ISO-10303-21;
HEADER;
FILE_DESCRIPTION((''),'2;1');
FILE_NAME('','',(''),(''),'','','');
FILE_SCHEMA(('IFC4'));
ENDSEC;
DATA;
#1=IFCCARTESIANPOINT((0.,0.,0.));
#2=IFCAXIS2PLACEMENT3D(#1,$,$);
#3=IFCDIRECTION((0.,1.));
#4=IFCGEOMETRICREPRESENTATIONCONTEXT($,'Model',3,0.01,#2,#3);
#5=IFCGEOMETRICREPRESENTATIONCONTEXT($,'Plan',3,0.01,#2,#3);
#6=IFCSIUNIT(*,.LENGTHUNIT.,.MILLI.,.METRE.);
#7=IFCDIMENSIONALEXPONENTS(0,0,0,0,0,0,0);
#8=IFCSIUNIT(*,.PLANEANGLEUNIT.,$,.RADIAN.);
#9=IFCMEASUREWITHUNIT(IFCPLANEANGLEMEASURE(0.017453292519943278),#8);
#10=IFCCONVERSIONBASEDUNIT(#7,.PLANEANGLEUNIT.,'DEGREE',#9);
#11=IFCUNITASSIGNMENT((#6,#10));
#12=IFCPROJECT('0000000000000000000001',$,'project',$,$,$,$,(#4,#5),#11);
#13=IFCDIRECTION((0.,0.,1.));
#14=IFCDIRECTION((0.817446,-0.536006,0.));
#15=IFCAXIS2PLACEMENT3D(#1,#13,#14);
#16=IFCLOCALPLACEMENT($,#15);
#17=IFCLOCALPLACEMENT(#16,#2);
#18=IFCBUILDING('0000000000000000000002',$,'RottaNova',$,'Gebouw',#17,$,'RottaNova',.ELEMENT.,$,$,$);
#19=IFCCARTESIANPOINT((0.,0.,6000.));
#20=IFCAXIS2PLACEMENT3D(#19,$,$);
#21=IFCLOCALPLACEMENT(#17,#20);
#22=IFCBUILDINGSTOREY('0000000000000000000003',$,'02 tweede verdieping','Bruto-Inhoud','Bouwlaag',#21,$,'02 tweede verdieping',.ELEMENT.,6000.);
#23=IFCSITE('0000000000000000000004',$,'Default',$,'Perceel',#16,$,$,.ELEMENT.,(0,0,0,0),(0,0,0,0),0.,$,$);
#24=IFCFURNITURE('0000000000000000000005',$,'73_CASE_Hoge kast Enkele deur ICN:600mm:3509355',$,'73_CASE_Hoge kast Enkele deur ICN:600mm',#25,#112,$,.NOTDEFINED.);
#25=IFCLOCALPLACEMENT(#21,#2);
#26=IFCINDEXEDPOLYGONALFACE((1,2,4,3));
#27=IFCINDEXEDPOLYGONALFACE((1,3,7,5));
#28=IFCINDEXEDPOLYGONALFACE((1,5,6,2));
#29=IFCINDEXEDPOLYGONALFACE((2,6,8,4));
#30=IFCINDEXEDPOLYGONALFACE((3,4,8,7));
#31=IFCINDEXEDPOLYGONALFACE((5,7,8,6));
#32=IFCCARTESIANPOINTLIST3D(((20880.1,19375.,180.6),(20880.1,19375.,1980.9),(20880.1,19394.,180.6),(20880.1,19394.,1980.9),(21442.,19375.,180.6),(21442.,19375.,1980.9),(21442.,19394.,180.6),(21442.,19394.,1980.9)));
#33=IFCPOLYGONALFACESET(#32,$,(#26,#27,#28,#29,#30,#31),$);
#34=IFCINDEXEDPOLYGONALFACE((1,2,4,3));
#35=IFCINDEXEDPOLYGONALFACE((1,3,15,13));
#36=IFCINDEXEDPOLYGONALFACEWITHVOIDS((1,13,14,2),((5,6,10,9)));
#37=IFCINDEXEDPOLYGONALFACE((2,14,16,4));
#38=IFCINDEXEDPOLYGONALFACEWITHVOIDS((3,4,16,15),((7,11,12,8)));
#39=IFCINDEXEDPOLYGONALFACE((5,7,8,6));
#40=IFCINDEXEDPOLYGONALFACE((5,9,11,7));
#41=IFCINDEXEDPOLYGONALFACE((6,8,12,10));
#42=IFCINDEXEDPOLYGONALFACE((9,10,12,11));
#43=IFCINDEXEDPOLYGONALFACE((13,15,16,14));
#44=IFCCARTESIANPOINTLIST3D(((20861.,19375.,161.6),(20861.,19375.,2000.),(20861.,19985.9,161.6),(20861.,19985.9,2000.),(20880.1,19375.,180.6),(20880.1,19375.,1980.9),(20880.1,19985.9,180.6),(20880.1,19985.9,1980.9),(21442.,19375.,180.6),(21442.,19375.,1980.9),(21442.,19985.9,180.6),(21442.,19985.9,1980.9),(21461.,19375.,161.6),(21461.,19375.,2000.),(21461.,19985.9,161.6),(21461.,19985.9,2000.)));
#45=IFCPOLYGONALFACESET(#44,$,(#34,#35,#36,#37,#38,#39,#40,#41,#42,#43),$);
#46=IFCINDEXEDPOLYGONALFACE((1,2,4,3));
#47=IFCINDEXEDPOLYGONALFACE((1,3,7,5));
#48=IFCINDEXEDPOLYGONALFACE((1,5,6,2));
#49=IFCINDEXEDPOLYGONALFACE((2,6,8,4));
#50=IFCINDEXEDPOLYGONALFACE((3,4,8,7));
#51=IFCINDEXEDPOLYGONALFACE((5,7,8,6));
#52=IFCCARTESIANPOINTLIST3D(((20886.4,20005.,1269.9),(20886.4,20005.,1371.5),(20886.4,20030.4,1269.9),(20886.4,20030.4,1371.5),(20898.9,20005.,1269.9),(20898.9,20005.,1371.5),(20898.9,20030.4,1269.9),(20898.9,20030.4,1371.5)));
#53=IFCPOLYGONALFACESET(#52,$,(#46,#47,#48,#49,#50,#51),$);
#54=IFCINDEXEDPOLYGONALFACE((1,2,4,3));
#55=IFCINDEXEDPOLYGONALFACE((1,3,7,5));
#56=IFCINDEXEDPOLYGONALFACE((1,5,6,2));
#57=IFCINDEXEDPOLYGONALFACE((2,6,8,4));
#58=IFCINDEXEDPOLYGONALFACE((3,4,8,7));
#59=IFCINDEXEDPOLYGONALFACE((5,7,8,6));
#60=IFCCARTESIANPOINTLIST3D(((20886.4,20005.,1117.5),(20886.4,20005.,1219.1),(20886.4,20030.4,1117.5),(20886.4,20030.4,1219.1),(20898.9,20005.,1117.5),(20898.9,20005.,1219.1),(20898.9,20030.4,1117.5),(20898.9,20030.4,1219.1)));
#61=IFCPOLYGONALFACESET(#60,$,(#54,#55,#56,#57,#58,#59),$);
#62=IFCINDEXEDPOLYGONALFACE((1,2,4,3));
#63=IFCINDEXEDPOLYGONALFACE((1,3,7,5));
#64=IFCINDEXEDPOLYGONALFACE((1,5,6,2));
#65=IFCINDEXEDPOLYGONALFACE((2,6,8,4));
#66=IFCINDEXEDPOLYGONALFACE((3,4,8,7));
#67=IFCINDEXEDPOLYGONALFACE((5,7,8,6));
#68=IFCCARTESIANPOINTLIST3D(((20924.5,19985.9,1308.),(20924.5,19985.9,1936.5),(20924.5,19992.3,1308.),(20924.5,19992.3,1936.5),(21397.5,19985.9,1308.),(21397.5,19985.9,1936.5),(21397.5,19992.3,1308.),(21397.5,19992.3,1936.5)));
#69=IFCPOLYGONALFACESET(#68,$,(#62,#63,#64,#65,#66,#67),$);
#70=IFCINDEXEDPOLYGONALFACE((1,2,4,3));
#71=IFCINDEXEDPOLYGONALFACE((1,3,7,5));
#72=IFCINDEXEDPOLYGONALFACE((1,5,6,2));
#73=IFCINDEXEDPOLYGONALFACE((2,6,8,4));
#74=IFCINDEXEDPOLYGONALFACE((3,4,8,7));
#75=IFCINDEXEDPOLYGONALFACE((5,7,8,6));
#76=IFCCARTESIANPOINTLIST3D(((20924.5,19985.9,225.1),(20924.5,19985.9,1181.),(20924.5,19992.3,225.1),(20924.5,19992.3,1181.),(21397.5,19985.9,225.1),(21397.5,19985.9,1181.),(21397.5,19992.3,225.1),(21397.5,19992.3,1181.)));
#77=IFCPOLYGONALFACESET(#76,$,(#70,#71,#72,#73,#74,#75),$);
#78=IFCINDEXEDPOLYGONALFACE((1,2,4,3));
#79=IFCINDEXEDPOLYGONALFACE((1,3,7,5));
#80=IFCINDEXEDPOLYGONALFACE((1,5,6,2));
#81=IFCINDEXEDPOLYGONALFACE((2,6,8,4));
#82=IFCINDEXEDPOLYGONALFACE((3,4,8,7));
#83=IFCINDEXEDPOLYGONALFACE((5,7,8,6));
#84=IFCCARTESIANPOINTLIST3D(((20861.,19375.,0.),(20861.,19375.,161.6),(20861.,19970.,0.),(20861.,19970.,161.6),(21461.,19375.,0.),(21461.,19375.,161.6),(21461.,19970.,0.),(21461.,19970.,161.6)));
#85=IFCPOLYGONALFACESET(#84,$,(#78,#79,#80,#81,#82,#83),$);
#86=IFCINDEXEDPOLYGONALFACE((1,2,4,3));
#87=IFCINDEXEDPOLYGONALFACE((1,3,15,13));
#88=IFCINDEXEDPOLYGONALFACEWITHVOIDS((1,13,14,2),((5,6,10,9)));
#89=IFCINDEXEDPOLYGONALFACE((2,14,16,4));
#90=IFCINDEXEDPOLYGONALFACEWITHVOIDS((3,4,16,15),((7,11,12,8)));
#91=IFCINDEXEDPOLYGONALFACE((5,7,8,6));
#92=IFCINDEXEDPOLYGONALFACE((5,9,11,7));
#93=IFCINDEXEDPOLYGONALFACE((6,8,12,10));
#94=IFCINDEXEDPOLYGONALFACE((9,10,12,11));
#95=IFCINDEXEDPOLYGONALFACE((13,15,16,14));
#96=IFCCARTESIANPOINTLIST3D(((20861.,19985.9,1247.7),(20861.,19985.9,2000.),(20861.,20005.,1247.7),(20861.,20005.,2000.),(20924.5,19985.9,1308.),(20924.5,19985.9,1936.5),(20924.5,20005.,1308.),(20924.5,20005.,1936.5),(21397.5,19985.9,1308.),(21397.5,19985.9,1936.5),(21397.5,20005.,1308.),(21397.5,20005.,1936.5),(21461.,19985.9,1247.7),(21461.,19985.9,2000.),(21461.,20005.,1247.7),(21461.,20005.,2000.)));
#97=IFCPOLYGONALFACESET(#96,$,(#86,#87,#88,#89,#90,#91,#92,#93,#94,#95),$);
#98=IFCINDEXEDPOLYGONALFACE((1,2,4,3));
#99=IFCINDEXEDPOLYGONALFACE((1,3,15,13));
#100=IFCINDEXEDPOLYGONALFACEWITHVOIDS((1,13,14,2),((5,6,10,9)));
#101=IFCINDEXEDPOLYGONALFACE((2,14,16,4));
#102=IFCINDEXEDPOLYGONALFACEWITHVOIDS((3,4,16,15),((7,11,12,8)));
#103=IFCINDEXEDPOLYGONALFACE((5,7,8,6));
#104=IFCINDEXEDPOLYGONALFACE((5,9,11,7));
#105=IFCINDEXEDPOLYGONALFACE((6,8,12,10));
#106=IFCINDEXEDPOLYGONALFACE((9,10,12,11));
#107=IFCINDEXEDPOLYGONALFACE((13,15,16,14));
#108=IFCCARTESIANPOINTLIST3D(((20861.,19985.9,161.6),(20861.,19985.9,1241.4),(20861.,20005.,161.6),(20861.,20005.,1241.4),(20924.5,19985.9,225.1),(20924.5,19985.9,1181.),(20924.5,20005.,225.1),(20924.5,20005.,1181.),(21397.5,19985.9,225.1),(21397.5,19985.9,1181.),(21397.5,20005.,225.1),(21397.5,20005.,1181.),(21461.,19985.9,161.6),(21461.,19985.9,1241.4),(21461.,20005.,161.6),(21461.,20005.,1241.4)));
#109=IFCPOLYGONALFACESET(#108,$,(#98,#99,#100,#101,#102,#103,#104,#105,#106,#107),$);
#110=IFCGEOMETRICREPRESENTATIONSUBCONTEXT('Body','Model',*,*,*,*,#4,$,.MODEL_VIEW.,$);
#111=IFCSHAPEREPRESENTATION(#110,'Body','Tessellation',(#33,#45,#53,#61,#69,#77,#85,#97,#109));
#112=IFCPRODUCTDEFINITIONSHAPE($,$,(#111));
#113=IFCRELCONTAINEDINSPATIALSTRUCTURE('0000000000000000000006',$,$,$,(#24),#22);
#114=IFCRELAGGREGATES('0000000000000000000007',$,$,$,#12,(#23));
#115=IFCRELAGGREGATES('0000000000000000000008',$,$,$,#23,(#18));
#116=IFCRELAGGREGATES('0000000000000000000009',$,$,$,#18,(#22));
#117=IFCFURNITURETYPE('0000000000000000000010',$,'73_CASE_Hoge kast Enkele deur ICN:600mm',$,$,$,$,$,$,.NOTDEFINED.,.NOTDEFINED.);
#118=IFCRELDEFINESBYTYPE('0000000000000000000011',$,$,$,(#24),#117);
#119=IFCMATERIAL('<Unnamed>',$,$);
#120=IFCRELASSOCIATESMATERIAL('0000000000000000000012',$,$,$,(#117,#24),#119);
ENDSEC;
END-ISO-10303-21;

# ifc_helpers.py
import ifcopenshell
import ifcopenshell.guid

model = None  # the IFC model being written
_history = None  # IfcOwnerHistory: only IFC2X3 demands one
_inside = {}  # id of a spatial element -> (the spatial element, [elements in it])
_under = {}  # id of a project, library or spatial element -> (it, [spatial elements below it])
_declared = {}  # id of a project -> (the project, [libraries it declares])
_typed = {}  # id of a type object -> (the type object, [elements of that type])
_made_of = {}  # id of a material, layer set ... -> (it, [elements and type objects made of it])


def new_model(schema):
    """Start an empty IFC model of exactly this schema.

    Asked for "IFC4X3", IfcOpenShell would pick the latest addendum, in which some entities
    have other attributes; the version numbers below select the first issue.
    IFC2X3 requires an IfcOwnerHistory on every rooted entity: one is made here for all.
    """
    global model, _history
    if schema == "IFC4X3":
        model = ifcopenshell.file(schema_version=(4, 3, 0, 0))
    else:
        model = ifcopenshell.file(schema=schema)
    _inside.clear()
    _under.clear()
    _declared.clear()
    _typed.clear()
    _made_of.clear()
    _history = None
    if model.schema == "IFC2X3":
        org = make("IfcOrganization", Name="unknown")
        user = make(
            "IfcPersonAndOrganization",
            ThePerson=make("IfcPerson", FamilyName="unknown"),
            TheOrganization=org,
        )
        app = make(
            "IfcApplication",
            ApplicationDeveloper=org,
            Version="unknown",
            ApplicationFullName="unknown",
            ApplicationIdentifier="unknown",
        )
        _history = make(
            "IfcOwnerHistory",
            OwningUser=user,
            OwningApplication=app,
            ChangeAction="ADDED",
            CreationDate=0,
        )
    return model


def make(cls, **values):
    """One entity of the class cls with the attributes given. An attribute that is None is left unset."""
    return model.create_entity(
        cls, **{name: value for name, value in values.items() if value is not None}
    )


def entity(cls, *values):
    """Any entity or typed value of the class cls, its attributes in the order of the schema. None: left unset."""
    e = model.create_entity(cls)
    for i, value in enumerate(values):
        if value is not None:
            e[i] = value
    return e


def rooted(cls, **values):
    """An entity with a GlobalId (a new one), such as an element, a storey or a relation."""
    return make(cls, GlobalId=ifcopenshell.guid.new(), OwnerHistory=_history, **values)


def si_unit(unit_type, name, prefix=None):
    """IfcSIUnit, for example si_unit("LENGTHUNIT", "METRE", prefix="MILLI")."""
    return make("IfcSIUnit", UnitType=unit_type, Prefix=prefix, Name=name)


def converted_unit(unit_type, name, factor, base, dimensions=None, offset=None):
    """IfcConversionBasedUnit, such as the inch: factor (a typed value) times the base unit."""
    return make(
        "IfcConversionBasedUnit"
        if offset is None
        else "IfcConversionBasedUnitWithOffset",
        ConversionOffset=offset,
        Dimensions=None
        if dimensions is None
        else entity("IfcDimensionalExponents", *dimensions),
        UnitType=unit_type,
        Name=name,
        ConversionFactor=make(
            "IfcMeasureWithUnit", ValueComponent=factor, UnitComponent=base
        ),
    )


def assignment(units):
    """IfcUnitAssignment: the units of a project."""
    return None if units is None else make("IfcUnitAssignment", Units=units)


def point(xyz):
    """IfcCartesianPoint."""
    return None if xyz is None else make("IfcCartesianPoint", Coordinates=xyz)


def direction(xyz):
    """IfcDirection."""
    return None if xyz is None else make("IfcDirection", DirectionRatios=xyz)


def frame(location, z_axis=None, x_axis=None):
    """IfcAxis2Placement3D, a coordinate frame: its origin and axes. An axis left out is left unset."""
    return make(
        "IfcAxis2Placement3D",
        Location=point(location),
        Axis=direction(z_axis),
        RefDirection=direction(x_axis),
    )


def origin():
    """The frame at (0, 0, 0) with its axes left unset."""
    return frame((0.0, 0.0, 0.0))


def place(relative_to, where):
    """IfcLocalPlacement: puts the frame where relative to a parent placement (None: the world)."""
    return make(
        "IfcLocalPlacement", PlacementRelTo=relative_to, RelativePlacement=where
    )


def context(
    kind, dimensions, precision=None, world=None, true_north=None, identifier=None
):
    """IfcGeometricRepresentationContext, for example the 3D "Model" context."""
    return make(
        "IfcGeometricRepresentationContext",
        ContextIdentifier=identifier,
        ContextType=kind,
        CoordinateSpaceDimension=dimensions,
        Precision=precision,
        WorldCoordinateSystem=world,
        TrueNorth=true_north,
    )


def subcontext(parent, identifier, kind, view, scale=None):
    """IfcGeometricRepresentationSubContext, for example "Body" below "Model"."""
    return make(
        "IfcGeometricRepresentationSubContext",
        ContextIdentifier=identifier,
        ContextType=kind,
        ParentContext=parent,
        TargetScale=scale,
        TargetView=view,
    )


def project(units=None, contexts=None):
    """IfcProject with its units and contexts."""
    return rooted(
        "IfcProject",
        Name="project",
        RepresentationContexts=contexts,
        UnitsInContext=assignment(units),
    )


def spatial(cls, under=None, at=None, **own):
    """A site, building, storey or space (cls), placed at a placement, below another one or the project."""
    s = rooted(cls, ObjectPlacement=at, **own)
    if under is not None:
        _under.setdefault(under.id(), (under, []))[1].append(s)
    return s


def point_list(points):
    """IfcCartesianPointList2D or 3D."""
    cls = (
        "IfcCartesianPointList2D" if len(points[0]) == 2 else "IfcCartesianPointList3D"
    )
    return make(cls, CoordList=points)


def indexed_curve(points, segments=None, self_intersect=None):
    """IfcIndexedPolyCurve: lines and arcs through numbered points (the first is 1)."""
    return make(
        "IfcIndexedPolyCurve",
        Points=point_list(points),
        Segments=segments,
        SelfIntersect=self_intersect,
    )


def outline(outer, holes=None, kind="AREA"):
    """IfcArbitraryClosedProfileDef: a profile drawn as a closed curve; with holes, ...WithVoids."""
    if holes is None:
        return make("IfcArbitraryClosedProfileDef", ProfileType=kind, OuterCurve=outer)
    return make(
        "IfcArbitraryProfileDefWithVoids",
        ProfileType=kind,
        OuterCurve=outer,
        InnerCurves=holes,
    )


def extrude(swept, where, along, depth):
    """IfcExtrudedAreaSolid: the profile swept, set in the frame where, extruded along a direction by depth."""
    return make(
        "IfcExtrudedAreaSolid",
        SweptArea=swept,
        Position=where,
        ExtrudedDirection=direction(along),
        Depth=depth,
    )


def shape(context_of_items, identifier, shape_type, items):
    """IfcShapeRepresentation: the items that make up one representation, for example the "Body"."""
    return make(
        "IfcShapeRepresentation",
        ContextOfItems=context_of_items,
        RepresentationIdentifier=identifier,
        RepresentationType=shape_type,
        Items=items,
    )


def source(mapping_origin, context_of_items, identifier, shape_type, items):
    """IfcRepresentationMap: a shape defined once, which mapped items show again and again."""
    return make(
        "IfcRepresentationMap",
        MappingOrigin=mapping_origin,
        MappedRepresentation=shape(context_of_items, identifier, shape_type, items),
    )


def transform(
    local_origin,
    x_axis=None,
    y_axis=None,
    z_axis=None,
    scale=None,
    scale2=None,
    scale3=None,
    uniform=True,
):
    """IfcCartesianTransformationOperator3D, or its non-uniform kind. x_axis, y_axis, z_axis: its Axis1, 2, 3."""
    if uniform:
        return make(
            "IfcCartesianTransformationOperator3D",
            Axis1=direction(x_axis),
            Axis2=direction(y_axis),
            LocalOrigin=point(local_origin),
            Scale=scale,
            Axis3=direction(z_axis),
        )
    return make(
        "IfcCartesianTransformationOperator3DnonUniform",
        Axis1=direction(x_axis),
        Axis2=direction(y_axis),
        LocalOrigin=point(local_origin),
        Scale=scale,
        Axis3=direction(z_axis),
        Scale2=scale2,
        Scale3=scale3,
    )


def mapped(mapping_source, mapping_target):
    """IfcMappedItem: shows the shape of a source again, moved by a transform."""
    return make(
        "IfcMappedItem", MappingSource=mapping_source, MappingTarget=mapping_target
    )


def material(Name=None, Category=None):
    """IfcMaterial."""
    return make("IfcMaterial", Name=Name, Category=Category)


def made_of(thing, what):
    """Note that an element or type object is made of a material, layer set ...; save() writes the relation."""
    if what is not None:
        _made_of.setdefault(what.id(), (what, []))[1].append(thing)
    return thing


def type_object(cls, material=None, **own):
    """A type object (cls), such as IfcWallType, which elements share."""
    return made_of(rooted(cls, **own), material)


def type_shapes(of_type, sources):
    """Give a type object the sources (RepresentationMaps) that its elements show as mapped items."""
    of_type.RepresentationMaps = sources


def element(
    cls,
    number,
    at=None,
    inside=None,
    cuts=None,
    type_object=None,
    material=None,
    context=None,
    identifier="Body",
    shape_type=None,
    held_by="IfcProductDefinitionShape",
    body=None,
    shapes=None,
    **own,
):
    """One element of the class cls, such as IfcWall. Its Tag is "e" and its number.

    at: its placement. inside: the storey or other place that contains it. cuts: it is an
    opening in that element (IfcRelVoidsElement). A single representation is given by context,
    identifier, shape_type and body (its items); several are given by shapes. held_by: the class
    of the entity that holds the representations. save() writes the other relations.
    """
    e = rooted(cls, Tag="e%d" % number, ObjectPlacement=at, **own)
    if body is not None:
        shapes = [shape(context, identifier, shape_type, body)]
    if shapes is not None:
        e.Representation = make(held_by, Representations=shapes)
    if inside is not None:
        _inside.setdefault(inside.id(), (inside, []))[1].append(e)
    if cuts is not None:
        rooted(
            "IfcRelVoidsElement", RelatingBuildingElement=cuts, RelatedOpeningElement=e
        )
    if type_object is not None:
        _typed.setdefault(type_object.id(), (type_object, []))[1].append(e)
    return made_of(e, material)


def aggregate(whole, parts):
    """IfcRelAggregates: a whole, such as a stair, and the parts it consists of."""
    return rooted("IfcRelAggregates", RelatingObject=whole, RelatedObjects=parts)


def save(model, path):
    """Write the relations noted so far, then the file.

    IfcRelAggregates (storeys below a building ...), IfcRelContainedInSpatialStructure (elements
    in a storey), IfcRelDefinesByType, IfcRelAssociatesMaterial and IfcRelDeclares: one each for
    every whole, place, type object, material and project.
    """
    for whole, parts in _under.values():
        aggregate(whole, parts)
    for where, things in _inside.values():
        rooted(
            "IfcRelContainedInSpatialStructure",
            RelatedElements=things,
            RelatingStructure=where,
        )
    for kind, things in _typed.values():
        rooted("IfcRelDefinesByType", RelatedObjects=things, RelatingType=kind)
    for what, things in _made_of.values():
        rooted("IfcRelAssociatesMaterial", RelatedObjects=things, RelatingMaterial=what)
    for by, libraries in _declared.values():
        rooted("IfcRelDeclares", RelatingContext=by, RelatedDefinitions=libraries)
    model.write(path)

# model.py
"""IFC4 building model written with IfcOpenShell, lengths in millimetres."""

from ifc_helpers import new_model, entity, si_unit, converted_unit, direction, frame, origin, place, context, subcontext, project, spatial, indexed_curve, outline, extrude, source, transform, mapped, material, type_object, type_shapes, element, save


model = new_model("IFC4")

# Units and contexts
model_context = context("Model", 3, precision=0.01, world=origin(), true_north=direction((0.0, 1.0)))
plan_context = context("Plan", 3, precision=0.01, world=origin(), true_north=direction((0.0, 1.0)))
body_context = subcontext(model_context, "Body", "Model", "MODEL_VIEW")
ifc_project = project(units=[si_unit("LENGTHUNIT", "METRE", prefix="MILLI"), converted_unit("PLANEANGLEUNIT", "DEGREE", entity("IfcPlaneAngleMeasure", 0.017453292519943278), si_unit("PLANEANGLEUNIT", "RADIAN"), dimensions=[0, 0, 0, 0, 0, 0, 0])], contexts=[model_context, plan_context])

# Site, building, storey
site_placement = place(None, frame((0.0, 0.0, 0.0), z_axis=(0.0, 0.0, 1.0), x_axis=(0.817446, -0.536006, 0.0)))
site = spatial("IfcSite", under=ifc_project, at=site_placement, Name="Default", ObjectType="Perceel", CompositionType="ELEMENT", RefLatitude=(0, 0, 0, 0), RefLongitude=(0, 0, 0, 0), RefElevation=0.0)
building_placement = place(site_placement, origin())
building = spatial("IfcBuilding", under=site, at=building_placement, Name="RottaNova", ObjectType="Gebouw", LongName="RottaNova", CompositionType="ELEMENT")
storey_placement = place(building_placement, frame((0.0, 0.0, 6000.0)))
storey = spatial("IfcBuildingStorey", under=building, at=storey_placement, Name="02 tweede verdieping", Description="Bruto-Inhoud", ObjectType="Bouwlaag", LongName="02 tweede verdieping", CompositionType="ELEMENT", Elevation=6000.0)

# Furniture
ifc_material_1 = material(Name="<Unnamed>")
furniture_type = type_object("IfcFurnitureType", Name="73_CASE_Hoge kast Enkele deur ICN:600mm", AssemblyPlace="NOTDEFINED", PredefinedType="NOTDEFINED", material=ifc_material_1)
shared_shape_1 = source(origin(), body_context, "Body", "SweptSolid", [
    extrude(outline(indexed_curve([(-9.5, -280.9), (9.5, -280.9), (9.5, 280.9), (-9.5, 280.9), (-9.5, -280.9)], self_intersect=False)), frame((18.7, -9.5, 180.6), z_axis=(0.0, 0.0, 1.0), x_axis=(0.0, 1.0, 0.0)), (0.0, 0.0, 1.0), 1800.3),
    extrude(outline(indexed_curve([(-300.0, -919.2), (300.0, -919.2), (300.0, 919.2), (-300.0, 919.2), (-300.0, -919.2)], self_intersect=False), holes=[indexed_curve([(-280.9, 900.2), (281.0, 900.2), (281.0, -900.2), (-280.9, -900.2), (-280.9, 900.2)], self_intersect=False)]), frame((18.7, -610.9, 1080.8), z_axis=(0.0, 1.0, 0.0), x_axis=(-1.0, 0.0, 0.0)), (0.0, 0.0, 1.0), 610.9),
    extrude(outline(indexed_curve([(-12.7, -6.3), (12.7, -6.3), (12.7, 6.3), (-12.7, 6.3), (-12.7, -6.3)], self_intersect=False)), frame((287.1, -642.7, 1269.9), z_axis=(0.0, 0.0, 1.0), x_axis=(0.0, 1.0, 0.0)), (0.0, 0.0, 1.0), 101.6),
    extrude(outline(indexed_curve([(-12.7, -6.3), (12.7, -6.3), (12.7, 6.3), (-12.7, 6.3), (-12.7, -6.3)], self_intersect=False)), frame((287.1, -642.7, 1117.5), z_axis=(0.0, 0.0, 1.0), x_axis=(0.0, 1.0, 0.0)), (0.0, 0.0, 1.0), 101.6),
    extrude(outline(indexed_curve([(-3.2, -236.5), (3.2, -236.5), (3.2, 236.5), (-3.2, 236.5), (-3.2, -236.5)], self_intersect=False)), frame((18.7, -614.1, 1308.0), z_axis=(0.0, 0.0, 1.0), x_axis=(0.0, 1.0, 0.0)), (0.0, 0.0, 1.0), 628.5),
    extrude(outline(indexed_curve([(-3.2, -236.5), (3.2, -236.5), (3.2, 236.5), (-3.2, 236.5), (-3.2, -236.5)], self_intersect=False)), frame((18.7, -614.1, 225.1), z_axis=(0.0, 0.0, 1.0), x_axis=(0.0, 1.0, 0.0)), (0.0, 0.0, 1.0), 956.0),
    extrude(outline(indexed_curve([(-300.0, -297.5), (300.0, -297.5), (300.0, 297.5), (-300.0, 297.5), (-300.0, -297.5)], self_intersect=False)), frame((18.7, -297.5, 0.0), z_axis=(0.0, 0.0, 1.0), x_axis=(-1.0, 0.0, 0.0)), (0.0, 0.0, 1.0), 161.6),
    extrude(outline(indexed_curve([(-376.1, -300.0), (376.1, -300.0), (376.1, 300.0), (-376.1, 300.0), (-376.1, -300.0)], self_intersect=False), holes=[indexed_curve([(-312.6, -236.5), (-312.6, 236.5), (315.8, 236.5), (315.8, -236.5), (-312.6, -236.5)], self_intersect=False)]), frame((18.7, -630.0, 1623.9), z_axis=(0.0, 1.0, 0.0), x_axis=(0.0, 0.0, -1.0)), (0.0, 0.0, 1.0), 19.1),
    extrude(outline(indexed_curve([(-300.0, -539.9), (300.0, -539.9), (300.0, 539.9), (-300.0, 539.9), (-300.0, -539.9)], self_intersect=False), holes=[indexed_curve([(-236.5, 479.6), (236.5, 479.6), (236.5, -476.4), (-236.5, -476.4), (-236.5, 479.6)], self_intersect=False)]), frame((18.7, -630.0, 701.5), z_axis=(0.0, 1.0, 0.0), x_axis=(-1.0, 0.0, 0.0)), (0.0, 0.0, 1.0), 19.1),
])
type_shapes(furniture_type, [shared_shape_1])
for number, where, z_axis, x_axis, name in (
    (1, (21179.7, 19375.0, 0.0), (0.0, 0.0, 1.0), (-1.0, 0.0, 0.0), "73_CASE_Hoge kast Enkele deur ICN:600mm:3509355"),
):
    element("IfcFurniture", number, at=place(storey_placement, frame(where, z_axis=z_axis, x_axis=x_axis)), inside=storey, type_object=furniture_type, material=ifc_material_1, Name=name, ObjectType="73_CASE_Hoge kast Enkele deur ICN:600mm", PredefinedType="NOTDEFINED", context=body_context, shape_type="MappedRepresentation", body=[
        mapped(shared_shape_1, transform((0.0, 0.0, 0.0), scale=1.0)),
    ])

save(model, "model.ifc")
